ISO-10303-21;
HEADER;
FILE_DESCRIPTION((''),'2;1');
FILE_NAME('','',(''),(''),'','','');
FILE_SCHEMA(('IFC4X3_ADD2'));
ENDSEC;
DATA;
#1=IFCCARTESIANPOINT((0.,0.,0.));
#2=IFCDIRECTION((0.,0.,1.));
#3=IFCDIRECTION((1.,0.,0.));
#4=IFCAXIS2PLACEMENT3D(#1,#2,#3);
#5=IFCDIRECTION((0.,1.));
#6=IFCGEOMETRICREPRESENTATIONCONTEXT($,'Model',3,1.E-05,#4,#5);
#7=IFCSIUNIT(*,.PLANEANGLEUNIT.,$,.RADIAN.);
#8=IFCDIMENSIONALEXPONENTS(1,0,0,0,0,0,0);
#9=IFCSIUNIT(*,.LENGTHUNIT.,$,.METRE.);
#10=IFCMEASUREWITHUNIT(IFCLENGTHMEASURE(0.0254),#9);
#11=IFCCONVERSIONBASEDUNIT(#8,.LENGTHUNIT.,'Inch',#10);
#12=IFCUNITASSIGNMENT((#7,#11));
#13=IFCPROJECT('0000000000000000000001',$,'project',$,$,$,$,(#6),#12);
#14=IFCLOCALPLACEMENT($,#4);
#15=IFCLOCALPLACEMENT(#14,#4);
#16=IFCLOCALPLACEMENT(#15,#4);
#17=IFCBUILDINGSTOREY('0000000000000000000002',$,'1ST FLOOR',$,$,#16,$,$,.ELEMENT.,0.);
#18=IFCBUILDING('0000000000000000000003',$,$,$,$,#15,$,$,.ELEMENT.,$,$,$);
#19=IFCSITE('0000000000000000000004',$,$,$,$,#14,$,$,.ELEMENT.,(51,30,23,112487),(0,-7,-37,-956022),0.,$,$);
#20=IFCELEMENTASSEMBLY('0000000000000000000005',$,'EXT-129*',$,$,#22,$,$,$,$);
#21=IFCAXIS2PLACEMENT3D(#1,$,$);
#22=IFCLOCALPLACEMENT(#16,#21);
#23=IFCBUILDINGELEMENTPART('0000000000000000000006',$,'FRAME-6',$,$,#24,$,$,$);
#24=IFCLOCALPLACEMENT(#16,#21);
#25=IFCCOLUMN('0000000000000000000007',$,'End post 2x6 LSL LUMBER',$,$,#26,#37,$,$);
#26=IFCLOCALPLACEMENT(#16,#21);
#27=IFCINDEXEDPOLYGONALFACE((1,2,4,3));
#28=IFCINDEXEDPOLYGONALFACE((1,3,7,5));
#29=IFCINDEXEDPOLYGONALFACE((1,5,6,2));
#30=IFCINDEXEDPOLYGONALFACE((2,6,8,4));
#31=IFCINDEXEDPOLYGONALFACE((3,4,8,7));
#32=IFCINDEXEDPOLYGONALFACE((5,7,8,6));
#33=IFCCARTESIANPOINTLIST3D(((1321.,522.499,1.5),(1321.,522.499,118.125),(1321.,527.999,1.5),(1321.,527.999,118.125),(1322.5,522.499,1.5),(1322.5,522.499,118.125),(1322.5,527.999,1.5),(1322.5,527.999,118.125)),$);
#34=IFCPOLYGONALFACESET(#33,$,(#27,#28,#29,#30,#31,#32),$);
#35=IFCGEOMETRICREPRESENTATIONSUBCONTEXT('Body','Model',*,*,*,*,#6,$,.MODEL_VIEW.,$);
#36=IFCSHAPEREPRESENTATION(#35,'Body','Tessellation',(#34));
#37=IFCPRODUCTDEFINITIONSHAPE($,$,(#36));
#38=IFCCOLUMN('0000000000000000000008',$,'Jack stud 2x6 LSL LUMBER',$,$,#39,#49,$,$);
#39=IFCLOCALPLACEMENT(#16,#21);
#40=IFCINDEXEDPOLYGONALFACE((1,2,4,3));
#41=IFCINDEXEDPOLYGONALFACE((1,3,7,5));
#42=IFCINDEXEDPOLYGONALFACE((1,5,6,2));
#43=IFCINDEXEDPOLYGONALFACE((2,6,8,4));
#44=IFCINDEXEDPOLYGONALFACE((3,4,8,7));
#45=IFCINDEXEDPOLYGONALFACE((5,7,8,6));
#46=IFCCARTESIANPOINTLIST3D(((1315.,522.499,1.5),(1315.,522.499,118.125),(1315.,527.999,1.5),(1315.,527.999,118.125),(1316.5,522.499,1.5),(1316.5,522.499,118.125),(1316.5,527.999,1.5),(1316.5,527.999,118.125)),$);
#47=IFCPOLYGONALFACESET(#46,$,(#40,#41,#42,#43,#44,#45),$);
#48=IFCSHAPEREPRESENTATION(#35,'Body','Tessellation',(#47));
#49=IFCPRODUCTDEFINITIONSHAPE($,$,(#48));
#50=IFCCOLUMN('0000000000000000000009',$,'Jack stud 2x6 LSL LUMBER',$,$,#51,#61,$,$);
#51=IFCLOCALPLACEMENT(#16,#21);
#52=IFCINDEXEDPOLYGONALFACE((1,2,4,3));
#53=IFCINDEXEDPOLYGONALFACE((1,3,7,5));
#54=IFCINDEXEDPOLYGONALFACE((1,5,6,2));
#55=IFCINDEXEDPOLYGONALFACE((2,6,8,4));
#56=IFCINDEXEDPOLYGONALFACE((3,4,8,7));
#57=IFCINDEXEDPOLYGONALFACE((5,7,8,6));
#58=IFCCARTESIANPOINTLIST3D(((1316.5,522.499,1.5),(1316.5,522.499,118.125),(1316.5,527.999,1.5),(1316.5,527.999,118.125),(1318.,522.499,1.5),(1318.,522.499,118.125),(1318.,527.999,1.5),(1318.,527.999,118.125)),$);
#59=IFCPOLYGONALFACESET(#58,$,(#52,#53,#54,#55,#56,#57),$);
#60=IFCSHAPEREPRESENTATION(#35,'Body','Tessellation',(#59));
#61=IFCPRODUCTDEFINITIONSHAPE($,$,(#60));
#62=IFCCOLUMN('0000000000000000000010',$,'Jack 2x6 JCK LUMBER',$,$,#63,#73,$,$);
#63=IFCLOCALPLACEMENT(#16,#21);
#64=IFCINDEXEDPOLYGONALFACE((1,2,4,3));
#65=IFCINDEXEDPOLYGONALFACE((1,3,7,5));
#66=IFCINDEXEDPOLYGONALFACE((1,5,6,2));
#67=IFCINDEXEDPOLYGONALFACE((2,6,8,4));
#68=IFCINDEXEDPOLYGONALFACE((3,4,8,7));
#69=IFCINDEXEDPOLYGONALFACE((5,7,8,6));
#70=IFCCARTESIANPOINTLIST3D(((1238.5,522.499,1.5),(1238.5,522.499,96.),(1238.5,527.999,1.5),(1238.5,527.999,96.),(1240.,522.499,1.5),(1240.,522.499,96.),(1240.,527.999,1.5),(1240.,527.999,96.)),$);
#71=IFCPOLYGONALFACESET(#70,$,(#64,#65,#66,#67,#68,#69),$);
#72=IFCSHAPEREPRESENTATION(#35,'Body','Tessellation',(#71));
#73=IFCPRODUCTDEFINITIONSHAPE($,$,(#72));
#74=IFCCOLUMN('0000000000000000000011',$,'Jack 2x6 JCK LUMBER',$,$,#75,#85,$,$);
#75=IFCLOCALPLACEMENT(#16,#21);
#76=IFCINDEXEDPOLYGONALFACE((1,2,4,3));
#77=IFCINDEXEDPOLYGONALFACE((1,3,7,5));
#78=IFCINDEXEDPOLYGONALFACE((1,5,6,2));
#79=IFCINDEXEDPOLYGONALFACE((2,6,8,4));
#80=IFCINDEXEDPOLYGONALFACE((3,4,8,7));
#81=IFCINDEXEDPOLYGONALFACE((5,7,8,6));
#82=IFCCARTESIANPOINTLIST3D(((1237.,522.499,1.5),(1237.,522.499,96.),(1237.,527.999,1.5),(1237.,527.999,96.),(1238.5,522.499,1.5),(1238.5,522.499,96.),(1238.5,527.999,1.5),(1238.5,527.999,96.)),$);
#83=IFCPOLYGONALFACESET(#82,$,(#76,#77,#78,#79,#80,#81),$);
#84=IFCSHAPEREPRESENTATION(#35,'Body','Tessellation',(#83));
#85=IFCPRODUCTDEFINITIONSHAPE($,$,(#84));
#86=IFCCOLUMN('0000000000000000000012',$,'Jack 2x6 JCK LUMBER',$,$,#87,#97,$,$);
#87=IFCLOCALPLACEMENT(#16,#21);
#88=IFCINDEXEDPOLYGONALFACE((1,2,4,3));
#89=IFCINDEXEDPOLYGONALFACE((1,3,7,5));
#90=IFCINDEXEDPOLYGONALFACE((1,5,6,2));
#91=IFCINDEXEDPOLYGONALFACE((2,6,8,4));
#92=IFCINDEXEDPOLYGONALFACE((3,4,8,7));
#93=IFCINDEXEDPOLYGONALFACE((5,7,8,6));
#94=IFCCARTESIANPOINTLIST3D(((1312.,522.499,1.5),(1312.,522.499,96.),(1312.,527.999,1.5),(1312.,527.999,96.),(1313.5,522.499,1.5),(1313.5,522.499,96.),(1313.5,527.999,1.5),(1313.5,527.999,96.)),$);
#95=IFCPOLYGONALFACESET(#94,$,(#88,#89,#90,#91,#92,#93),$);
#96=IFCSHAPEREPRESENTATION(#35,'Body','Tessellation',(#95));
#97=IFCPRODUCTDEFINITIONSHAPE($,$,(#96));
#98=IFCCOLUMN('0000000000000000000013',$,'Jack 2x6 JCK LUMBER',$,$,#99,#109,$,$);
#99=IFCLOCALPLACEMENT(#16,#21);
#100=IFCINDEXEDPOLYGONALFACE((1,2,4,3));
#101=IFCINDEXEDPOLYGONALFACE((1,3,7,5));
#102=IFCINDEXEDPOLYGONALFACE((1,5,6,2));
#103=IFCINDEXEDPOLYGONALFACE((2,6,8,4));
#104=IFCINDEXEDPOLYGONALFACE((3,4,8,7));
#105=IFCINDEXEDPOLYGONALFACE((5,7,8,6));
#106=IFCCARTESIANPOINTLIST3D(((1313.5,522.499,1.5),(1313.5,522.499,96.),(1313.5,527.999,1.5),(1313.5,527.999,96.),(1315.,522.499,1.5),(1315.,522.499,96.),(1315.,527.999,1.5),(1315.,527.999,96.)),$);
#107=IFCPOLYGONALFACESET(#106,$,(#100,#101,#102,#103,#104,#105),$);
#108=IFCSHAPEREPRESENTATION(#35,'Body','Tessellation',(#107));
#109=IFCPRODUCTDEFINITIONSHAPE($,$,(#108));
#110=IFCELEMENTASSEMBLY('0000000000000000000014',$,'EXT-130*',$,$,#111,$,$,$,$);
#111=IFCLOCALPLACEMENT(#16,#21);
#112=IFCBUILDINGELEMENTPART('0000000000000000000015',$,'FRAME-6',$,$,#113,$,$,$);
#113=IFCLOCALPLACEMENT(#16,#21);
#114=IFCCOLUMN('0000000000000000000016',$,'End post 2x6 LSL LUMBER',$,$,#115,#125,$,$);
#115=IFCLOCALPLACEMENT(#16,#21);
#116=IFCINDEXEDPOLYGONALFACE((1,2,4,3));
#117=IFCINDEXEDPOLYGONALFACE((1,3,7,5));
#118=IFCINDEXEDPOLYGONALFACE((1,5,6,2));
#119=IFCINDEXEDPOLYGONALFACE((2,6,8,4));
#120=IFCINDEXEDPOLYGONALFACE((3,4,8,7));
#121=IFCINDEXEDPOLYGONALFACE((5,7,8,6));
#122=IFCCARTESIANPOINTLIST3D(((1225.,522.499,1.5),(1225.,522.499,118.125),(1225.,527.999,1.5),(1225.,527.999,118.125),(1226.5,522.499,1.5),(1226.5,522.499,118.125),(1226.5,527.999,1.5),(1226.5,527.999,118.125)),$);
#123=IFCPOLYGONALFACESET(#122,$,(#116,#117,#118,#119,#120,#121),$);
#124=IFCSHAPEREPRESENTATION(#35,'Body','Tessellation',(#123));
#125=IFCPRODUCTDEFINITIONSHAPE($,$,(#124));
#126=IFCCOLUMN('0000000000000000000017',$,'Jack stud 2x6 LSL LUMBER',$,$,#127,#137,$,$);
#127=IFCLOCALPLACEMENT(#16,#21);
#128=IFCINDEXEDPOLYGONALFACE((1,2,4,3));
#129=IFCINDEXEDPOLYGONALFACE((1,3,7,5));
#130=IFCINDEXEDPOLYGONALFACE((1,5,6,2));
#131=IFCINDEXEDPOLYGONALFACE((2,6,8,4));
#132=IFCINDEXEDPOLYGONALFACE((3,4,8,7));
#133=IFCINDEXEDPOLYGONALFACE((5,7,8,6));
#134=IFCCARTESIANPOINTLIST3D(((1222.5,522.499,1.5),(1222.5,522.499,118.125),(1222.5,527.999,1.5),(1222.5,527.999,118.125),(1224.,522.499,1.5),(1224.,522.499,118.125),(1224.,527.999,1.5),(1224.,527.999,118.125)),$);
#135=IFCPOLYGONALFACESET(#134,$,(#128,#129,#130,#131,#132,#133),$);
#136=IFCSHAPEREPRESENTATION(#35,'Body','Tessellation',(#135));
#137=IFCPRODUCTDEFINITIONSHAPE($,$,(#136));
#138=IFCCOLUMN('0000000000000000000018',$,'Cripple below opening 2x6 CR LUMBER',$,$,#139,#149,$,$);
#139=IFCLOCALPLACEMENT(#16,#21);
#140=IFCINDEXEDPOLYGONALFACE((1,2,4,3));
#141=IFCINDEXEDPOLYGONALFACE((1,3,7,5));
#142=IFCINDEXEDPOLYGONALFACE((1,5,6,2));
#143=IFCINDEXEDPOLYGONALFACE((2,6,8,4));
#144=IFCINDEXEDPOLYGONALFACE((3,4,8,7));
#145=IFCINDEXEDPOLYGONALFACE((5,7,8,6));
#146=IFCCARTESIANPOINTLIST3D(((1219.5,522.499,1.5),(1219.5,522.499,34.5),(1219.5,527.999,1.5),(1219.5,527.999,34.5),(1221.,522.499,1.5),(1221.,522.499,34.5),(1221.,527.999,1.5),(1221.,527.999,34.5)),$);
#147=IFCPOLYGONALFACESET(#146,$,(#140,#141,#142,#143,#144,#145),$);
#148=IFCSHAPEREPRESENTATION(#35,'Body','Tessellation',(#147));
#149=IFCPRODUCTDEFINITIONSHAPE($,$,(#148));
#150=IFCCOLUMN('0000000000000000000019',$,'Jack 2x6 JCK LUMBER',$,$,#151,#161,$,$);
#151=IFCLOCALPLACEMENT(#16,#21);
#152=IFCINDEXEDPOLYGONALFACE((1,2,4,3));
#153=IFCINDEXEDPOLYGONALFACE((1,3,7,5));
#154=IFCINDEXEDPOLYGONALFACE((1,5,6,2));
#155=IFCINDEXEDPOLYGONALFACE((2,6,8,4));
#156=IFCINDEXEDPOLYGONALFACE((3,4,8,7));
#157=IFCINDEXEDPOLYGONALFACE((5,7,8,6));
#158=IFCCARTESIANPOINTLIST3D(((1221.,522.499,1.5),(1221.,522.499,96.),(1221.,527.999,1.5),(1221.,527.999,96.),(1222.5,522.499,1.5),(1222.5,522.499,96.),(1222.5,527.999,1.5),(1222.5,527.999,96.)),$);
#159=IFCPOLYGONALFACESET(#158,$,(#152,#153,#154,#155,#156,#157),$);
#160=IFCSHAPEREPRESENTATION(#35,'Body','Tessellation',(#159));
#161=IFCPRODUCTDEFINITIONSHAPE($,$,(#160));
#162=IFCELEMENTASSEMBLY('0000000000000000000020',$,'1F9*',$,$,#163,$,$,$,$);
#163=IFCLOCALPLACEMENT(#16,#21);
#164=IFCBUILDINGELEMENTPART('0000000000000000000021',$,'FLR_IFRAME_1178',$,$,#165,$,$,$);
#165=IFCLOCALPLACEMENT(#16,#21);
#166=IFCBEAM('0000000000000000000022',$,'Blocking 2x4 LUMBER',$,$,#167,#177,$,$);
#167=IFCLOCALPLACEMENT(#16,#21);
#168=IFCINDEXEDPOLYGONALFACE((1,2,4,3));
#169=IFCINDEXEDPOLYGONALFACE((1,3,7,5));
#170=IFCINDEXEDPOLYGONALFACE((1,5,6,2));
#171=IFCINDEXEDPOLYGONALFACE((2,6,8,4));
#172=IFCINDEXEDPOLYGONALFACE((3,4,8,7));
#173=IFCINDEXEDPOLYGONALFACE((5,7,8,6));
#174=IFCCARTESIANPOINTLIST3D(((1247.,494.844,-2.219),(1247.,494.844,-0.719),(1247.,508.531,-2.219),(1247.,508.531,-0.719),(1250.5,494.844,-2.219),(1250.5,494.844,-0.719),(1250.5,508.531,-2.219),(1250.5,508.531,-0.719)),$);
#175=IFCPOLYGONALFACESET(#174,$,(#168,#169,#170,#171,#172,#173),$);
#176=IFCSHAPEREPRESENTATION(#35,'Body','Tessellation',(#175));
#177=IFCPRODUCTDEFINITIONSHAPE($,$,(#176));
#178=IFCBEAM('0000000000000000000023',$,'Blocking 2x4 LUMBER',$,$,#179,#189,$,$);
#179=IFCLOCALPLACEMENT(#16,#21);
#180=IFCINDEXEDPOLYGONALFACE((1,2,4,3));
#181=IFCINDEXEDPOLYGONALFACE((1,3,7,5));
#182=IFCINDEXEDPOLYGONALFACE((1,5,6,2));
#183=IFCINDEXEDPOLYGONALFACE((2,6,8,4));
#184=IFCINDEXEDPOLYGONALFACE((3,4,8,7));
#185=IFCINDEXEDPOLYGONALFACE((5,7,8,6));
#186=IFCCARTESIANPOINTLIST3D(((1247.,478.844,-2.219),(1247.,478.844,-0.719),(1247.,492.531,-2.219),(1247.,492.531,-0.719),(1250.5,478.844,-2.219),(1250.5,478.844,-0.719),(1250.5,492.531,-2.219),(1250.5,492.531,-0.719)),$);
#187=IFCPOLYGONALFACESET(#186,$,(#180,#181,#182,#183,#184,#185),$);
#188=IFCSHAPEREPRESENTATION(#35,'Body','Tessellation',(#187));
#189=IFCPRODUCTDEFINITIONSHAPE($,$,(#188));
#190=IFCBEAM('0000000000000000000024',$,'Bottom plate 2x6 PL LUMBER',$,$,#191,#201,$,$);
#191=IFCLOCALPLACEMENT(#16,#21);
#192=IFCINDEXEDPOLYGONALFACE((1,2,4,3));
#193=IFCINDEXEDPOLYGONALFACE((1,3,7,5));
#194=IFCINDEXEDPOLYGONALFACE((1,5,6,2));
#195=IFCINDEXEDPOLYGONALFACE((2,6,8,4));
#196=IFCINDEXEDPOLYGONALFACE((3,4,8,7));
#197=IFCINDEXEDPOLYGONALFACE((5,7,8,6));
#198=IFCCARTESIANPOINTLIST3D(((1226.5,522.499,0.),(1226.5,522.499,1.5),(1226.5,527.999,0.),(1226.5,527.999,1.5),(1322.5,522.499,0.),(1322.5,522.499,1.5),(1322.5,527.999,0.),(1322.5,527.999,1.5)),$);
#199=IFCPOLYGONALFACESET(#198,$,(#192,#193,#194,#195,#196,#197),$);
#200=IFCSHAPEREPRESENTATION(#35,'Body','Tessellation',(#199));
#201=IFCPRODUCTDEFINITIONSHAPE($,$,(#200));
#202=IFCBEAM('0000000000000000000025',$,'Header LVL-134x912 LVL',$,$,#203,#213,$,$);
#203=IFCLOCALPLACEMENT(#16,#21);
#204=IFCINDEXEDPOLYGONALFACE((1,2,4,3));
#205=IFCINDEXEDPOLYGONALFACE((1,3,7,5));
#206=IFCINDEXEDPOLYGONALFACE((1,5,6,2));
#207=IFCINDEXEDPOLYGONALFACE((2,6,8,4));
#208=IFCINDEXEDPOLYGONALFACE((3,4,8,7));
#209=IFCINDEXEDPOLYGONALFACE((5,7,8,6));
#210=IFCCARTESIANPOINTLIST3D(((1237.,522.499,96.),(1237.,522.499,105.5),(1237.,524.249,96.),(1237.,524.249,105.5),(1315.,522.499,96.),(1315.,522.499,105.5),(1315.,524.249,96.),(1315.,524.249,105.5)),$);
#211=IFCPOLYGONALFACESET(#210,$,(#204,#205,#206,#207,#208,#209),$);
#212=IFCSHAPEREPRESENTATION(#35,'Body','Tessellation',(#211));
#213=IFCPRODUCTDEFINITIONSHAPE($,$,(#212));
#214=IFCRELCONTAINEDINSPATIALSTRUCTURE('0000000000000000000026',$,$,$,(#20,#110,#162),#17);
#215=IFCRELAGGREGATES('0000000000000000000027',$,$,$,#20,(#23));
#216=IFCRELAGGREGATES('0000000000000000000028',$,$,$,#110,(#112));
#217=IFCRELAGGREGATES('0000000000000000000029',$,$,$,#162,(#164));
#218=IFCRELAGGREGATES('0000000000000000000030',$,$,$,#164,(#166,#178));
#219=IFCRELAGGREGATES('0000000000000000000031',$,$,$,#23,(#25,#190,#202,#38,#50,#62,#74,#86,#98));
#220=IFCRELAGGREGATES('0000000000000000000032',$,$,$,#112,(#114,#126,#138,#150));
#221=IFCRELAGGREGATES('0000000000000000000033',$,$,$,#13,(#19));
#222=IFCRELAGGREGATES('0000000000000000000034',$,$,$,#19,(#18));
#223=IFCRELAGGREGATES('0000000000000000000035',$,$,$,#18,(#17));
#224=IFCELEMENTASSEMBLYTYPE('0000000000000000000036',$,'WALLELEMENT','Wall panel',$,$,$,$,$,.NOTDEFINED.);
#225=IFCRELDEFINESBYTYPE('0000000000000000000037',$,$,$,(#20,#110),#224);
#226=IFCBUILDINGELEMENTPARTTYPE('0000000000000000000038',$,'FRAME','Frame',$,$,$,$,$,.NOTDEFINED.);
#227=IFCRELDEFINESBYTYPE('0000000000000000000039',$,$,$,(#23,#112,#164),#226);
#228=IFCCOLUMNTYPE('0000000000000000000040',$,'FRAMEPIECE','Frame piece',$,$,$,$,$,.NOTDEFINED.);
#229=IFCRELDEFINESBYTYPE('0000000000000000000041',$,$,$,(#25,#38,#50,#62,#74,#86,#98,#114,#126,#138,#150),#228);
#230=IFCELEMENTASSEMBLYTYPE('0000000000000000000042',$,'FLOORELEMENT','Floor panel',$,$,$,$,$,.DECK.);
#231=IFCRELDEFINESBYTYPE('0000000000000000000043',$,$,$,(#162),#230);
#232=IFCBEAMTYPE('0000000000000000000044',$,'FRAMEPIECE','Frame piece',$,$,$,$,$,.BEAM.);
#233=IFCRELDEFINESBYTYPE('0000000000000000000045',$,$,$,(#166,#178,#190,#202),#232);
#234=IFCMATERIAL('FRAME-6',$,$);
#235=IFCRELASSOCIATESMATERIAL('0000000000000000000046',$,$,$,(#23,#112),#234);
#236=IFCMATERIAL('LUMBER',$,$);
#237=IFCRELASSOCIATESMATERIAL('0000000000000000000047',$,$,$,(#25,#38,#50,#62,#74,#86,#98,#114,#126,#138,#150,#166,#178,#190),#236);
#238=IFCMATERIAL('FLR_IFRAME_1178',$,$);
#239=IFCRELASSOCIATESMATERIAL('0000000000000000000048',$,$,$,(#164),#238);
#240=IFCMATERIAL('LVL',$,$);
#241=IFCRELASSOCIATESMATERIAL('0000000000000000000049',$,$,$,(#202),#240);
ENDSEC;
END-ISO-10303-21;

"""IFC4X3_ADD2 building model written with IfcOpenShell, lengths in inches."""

from ifc_helpers import new_model, entity, si_unit, converted_unit, direction, frame, origin_with_axes, origin_2d_with_axis, place, context, subcontext, project, spatial, rectangle, extrude, material, type_object, element, aggregate, save


model = new_model("IFC4X3_ADD2")

# Units and contexts
model_context = context("Model", 3, precision=1e-05, world=origin_with_axes(), true_north=direction((0.0, 1.0)))
body_context = subcontext(model_context, "Body", "Model", "MODEL_VIEW")
ifc_project = project(units=[si_unit("PLANEANGLEUNIT", "RADIAN"), converted_unit("LENGTHUNIT", "Inch", entity("IfcLengthMeasure", 0.0254), si_unit("LENGTHUNIT", "METRE"), dimensions=[1, 0, 0, 0, 0, 0, 0])], contexts=[model_context])

# Site, building, storey
site_placement = place(None, origin_with_axes())
site = spatial("IfcSite", under=ifc_project, at=site_placement, CompositionType="ELEMENT", RefLatitude=(51, 30, 23, 112487), RefLongitude=(0, -7, -37, -956022), RefElevation=0.0)
building_placement = place(site_placement, origin_with_axes())
building = spatial("IfcBuilding", under=site, at=building_placement, CompositionType="ELEMENT")
storey_placement = place(building_placement, origin_with_axes())
storey = spatial("IfcBuildingStorey", under=building, at=storey_placement, Name="1ST FLOOR", CompositionType="ELEMENT", Elevation=0.0)

# Element assemblies, building element parts, columns
element_assembly_type_1 = type_object("IfcElementAssemblyType", Name="WALLELEMENT", Description="Wall panel", PredefinedType="NOTDEFINED")
assembly_1_placement = place(storey_placement, origin_with_axes())
assembly_1 = element("IfcElementAssembly", 1, at=assembly_1_placement, inside=storey, type_object=element_assembly_type_1, Name="EXT-129*")
ifc_material_1 = material(Name="FRAME-6")
building_element_part_type = type_object("IfcBuildingElementPartType", Name="FRAME", Description="Frame", PredefinedType="NOTDEFINED")
building_element_part_1_placement = place(storey_placement, origin_with_axes())
building_element_part_1 = element("IfcBuildingElementPart", 2, at=building_element_part_1_placement, type_object=building_element_part_type, material=ifc_material_1, Name="FRAME-6")
aggregate(assembly_1, [building_element_part_1])
ifc_material_2 = material(Name="LUMBER")
column_type = type_object("IfcColumnType", Name="FRAMEPIECE", Description="Frame piece", PredefinedType="NOTDEFINED")
column_1_placement = place(storey_placement, frame((1321.75, 525.249, 1.5), z_axis=(0.0, 0.0, 1.0), x_axis=(-1.0, 0.0, 0.0)))
column_1 = element("IfcColumn", 3, at=column_1_placement, type_object=column_type, material=ifc_material_2, Name="End post 2x6 LSL LUMBER", context=body_context, shape_type="SweptSolid", body=[
    extrude(rectangle(XDim=1.5, YDim=5.5, at=origin_2d_with_axis()), origin_with_axes(), (0.0, 0.0, 1.0), 116.625),
])
column_2_placement = place(storey_placement, frame((1315.75, 525.249, 1.5), z_axis=(0.0, 0.0, 1.0), x_axis=(-1.0, 0.0, 0.0)))
column_2 = element("IfcColumn", 4, at=column_2_placement, type_object=column_type, material=ifc_material_2, Name="Jack stud 2x6 LSL LUMBER", context=body_context, shape_type="SweptSolid", body=[
    extrude(rectangle(XDim=1.5, YDim=5.5, at=origin_2d_with_axis()), origin_with_axes(), (0.0, 0.0, 1.0), 116.625),
])
column_3_placement = place(storey_placement, frame((1317.25, 525.249, 1.5), z_axis=(0.0, 0.0, 1.0), x_axis=(-1.0, 0.0, 0.0)))
column_3 = element("IfcColumn", 5, at=column_3_placement, type_object=column_type, material=ifc_material_2, Name="Jack stud 2x6 LSL LUMBER", context=body_context, shape_type="SweptSolid", body=[
    extrude(rectangle(XDim=1.5, YDim=5.5, at=origin_2d_with_axis()), origin_with_axes(), (0.0, 0.0, 1.0), 116.625),
])
column_4_placement = place(storey_placement, frame((1239.25, 525.249, 96.0), z_axis=(0.0, 0.0, -1.0), x_axis=(1.0, 0.0, 0.0)))
column_4 = element("IfcColumn", 6, at=column_4_placement, type_object=column_type, material=ifc_material_2, Name="Jack 2x6 JCK LUMBER", context=body_context, shape_type="SweptSolid", body=[
    extrude(rectangle(XDim=1.5, YDim=5.5, at=origin_2d_with_axis()), origin_with_axes(), (0.0, 0.0, 1.0), 94.5),
])
column_5_placement = place(storey_placement, frame((1237.75, 525.249, 96.0), z_axis=(0.0, 0.0, -1.0), x_axis=(1.0, 0.0, 0.0)))
column_5 = element("IfcColumn", 7, at=column_5_placement, type_object=column_type, material=ifc_material_2, Name="Jack 2x6 JCK LUMBER", context=body_context, shape_type="SweptSolid", body=[
    extrude(rectangle(XDim=1.5, YDim=5.5, at=origin_2d_with_axis()), origin_with_axes(), (0.0, 0.0, 1.0), 94.5),
])
column_6_placement = place(storey_placement, frame((1312.75, 525.249, 1.5), z_axis=(0.0, 0.0, 1.0), x_axis=(-1.0, 0.0, 0.0)))
column_6 = element("IfcColumn", 8, at=column_6_placement, type_object=column_type, material=ifc_material_2, Name="Jack 2x6 JCK LUMBER", context=body_context, shape_type="SweptSolid", body=[
    extrude(rectangle(XDim=1.5, YDim=5.5, at=origin_2d_with_axis()), origin_with_axes(), (0.0, 0.0, 1.0), 94.5),
])
column_7_placement = place(storey_placement, frame((1314.25, 525.249, 1.5), z_axis=(0.0, 0.0, 1.0), x_axis=(-1.0, 0.0, 0.0)))
column_7 = element("IfcColumn", 9, at=column_7_placement, type_object=column_type, material=ifc_material_2, Name="Jack 2x6 JCK LUMBER", context=body_context, shape_type="SweptSolid", body=[
    extrude(rectangle(XDim=1.5, YDim=5.5, at=origin_2d_with_axis()), origin_with_axes(), (0.0, 0.0, 1.0), 94.5),
])
assembly_2_placement = place(storey_placement, origin_with_axes())
assembly_2 = element("IfcElementAssembly", 10, at=assembly_2_placement, inside=storey, type_object=element_assembly_type_1, Name="EXT-130*")
building_element_part_2_placement = place(storey_placement, origin_with_axes())
building_element_part_2 = element("IfcBuildingElementPart", 11, at=building_element_part_2_placement, type_object=building_element_part_type, material=ifc_material_1, Name="FRAME-6")
aggregate(assembly_2, [building_element_part_2])
column_8_placement = place(storey_placement, frame((1225.75, 525.249, 1.5), z_axis=(0.0, 0.0, 1.0), x_axis=(-1.0, 0.0, 0.0)))
column_8 = element("IfcColumn", 12, at=column_8_placement, type_object=column_type, material=ifc_material_2, Name="End post 2x6 LSL LUMBER", context=body_context, shape_type="SweptSolid", body=[
    extrude(rectangle(XDim=1.5, YDim=5.5, at=origin_2d_with_axis()), origin_with_axes(), (0.0, 0.0, 1.0), 116.625),
])
column_9_placement = place(storey_placement, frame((1223.25, 525.249, 1.5), z_axis=(0.0, 0.0, 1.0), x_axis=(-1.0, 0.0, 0.0)))
column_9 = element("IfcColumn", 13, at=column_9_placement, type_object=column_type, material=ifc_material_2, Name="Jack stud 2x6 LSL LUMBER", context=body_context, shape_type="SweptSolid", body=[
    extrude(rectangle(XDim=1.5, YDim=5.5, at=origin_2d_with_axis()), origin_with_axes(), (0.0, 0.0, 1.0), 116.625),
])
column_10_placement = place(storey_placement, frame((1220.25, 525.249, 1.5), z_axis=(0.0, 0.0, 1.0), x_axis=(-1.0, 0.0, 0.0)))
column_10 = element("IfcColumn", 14, at=column_10_placement, type_object=column_type, material=ifc_material_2, Name="Cripple below opening 2x6 CR LUMBER", context=body_context, shape_type="SweptSolid", body=[
    extrude(rectangle(XDim=1.5, YDim=5.5, at=origin_2d_with_axis()), origin_with_axes(), (0.0, 0.0, 1.0), 33.0),
])
column_11_placement = place(storey_placement, frame((1221.75, 525.249, 1.5), z_axis=(0.0, 0.0, 1.0), x_axis=(-1.0, 0.0, 0.0)))
column_11 = element("IfcColumn", 15, at=column_11_placement, type_object=column_type, material=ifc_material_2, Name="Jack 2x6 JCK LUMBER", context=body_context, shape_type="SweptSolid", body=[
    extrude(rectangle(XDim=1.5, YDim=5.5, at=origin_2d_with_axis()), origin_with_axes(), (0.0, 0.0, 1.0), 94.5),
])

# Element assembly, building element part, beams
element_assembly_type_2 = type_object("IfcElementAssemblyType", Name="FLOORELEMENT", Description="Floor panel", PredefinedType="DECK")
assembly_3_placement = place(storey_placement, origin_with_axes())
assembly_3 = element("IfcElementAssembly", 16, at=assembly_3_placement, inside=storey, type_object=element_assembly_type_2, Name="1F9*")
ifc_material_3 = material(Name="FLR_IFRAME_1178")
building_element_part_3_placement = place(storey_placement, origin_with_axes())
building_element_part_3 = element("IfcBuildingElementPart", 17, at=building_element_part_3_placement, type_object=building_element_part_type, material=ifc_material_3, Name="FLR_IFRAME_1178")
aggregate(assembly_3, [building_element_part_3])
beam_type_1 = type_object("IfcBeamType", Name="FRAMEPIECE", Description="Frame piece", PredefinedType="BEAM")
beam_1_placement = place(storey_placement, frame((1248.75, 508.531, -1.469), z_axis=(0.0, -1.0, 0.0), x_axis=(0.0, 0.0, 1.0)))
beam_1 = element("IfcBeam", 18, at=beam_1_placement, type_object=beam_type_1, material=ifc_material_2, Name="Blocking 2x4 LUMBER", context=body_context, shape_type="SweptSolid", body=[
    extrude(rectangle(XDim=1.5, YDim=3.5, at=origin_2d_with_axis()), origin_with_axes(), (0.0, 0.0, 1.0), 13.688),
])
beam_2_placement = place(storey_placement, frame((1248.75, 492.531, -1.469), z_axis=(0.0, -1.0, 0.0), x_axis=(0.0, 0.0, 1.0)))
beam_2 = element("IfcBeam", 19, at=beam_2_placement, type_object=beam_type_1, material=ifc_material_2, Name="Blocking 2x4 LUMBER", context=body_context, shape_type="SweptSolid", body=[
    extrude(rectangle(XDim=1.5, YDim=3.5, at=origin_2d_with_axis()), origin_with_axes(), (0.0, 0.0, 1.0), 13.688),
])
aggregate(building_element_part_3, [beam_1, beam_2])

# Beams
beam_3_placement = place(storey_placement, frame((1226.5, 525.249, 0.75), z_axis=(1.0, 0.0, 0.0), x_axis=(0.0, 0.0, 1.0)))
beam_3 = element("IfcBeam", 20, at=beam_3_placement, type_object=beam_type_1, material=ifc_material_2, Name="Bottom plate 2x6 PL LUMBER", context=body_context, shape_type="SweptSolid", body=[
    extrude(rectangle(XDim=1.5, YDim=5.5, at=origin_2d_with_axis()), origin_with_axes(), (0.0, 0.0, 1.0), 96.0),
])
ifc_material_4 = material(Name="LVL")
beam_4_placement = place(storey_placement, frame((1237.0, 523.374, 100.75), z_axis=(1.0, 0.0, 0.0), x_axis=(0.0, 1.0, 0.0)))
beam_4 = element("IfcBeam", 21, at=beam_4_placement, type_object=beam_type_1, material=ifc_material_4, Name="Header LVL-134x912 LVL", context=body_context, shape_type="SweptSolid", body=[
    extrude(rectangle(XDim=1.75, YDim=9.5, at=origin_2d_with_axis()), origin_with_axes(), (0.0, 0.0, 1.0), 78.0),
])
aggregate(building_element_part_1, [column_1, beam_3, beam_4, column_2, column_3, column_4, column_5, column_6, column_7])
aggregate(building_element_part_2, [column_8, column_9, column_10, column_11])

save(model, "model.ifc")
